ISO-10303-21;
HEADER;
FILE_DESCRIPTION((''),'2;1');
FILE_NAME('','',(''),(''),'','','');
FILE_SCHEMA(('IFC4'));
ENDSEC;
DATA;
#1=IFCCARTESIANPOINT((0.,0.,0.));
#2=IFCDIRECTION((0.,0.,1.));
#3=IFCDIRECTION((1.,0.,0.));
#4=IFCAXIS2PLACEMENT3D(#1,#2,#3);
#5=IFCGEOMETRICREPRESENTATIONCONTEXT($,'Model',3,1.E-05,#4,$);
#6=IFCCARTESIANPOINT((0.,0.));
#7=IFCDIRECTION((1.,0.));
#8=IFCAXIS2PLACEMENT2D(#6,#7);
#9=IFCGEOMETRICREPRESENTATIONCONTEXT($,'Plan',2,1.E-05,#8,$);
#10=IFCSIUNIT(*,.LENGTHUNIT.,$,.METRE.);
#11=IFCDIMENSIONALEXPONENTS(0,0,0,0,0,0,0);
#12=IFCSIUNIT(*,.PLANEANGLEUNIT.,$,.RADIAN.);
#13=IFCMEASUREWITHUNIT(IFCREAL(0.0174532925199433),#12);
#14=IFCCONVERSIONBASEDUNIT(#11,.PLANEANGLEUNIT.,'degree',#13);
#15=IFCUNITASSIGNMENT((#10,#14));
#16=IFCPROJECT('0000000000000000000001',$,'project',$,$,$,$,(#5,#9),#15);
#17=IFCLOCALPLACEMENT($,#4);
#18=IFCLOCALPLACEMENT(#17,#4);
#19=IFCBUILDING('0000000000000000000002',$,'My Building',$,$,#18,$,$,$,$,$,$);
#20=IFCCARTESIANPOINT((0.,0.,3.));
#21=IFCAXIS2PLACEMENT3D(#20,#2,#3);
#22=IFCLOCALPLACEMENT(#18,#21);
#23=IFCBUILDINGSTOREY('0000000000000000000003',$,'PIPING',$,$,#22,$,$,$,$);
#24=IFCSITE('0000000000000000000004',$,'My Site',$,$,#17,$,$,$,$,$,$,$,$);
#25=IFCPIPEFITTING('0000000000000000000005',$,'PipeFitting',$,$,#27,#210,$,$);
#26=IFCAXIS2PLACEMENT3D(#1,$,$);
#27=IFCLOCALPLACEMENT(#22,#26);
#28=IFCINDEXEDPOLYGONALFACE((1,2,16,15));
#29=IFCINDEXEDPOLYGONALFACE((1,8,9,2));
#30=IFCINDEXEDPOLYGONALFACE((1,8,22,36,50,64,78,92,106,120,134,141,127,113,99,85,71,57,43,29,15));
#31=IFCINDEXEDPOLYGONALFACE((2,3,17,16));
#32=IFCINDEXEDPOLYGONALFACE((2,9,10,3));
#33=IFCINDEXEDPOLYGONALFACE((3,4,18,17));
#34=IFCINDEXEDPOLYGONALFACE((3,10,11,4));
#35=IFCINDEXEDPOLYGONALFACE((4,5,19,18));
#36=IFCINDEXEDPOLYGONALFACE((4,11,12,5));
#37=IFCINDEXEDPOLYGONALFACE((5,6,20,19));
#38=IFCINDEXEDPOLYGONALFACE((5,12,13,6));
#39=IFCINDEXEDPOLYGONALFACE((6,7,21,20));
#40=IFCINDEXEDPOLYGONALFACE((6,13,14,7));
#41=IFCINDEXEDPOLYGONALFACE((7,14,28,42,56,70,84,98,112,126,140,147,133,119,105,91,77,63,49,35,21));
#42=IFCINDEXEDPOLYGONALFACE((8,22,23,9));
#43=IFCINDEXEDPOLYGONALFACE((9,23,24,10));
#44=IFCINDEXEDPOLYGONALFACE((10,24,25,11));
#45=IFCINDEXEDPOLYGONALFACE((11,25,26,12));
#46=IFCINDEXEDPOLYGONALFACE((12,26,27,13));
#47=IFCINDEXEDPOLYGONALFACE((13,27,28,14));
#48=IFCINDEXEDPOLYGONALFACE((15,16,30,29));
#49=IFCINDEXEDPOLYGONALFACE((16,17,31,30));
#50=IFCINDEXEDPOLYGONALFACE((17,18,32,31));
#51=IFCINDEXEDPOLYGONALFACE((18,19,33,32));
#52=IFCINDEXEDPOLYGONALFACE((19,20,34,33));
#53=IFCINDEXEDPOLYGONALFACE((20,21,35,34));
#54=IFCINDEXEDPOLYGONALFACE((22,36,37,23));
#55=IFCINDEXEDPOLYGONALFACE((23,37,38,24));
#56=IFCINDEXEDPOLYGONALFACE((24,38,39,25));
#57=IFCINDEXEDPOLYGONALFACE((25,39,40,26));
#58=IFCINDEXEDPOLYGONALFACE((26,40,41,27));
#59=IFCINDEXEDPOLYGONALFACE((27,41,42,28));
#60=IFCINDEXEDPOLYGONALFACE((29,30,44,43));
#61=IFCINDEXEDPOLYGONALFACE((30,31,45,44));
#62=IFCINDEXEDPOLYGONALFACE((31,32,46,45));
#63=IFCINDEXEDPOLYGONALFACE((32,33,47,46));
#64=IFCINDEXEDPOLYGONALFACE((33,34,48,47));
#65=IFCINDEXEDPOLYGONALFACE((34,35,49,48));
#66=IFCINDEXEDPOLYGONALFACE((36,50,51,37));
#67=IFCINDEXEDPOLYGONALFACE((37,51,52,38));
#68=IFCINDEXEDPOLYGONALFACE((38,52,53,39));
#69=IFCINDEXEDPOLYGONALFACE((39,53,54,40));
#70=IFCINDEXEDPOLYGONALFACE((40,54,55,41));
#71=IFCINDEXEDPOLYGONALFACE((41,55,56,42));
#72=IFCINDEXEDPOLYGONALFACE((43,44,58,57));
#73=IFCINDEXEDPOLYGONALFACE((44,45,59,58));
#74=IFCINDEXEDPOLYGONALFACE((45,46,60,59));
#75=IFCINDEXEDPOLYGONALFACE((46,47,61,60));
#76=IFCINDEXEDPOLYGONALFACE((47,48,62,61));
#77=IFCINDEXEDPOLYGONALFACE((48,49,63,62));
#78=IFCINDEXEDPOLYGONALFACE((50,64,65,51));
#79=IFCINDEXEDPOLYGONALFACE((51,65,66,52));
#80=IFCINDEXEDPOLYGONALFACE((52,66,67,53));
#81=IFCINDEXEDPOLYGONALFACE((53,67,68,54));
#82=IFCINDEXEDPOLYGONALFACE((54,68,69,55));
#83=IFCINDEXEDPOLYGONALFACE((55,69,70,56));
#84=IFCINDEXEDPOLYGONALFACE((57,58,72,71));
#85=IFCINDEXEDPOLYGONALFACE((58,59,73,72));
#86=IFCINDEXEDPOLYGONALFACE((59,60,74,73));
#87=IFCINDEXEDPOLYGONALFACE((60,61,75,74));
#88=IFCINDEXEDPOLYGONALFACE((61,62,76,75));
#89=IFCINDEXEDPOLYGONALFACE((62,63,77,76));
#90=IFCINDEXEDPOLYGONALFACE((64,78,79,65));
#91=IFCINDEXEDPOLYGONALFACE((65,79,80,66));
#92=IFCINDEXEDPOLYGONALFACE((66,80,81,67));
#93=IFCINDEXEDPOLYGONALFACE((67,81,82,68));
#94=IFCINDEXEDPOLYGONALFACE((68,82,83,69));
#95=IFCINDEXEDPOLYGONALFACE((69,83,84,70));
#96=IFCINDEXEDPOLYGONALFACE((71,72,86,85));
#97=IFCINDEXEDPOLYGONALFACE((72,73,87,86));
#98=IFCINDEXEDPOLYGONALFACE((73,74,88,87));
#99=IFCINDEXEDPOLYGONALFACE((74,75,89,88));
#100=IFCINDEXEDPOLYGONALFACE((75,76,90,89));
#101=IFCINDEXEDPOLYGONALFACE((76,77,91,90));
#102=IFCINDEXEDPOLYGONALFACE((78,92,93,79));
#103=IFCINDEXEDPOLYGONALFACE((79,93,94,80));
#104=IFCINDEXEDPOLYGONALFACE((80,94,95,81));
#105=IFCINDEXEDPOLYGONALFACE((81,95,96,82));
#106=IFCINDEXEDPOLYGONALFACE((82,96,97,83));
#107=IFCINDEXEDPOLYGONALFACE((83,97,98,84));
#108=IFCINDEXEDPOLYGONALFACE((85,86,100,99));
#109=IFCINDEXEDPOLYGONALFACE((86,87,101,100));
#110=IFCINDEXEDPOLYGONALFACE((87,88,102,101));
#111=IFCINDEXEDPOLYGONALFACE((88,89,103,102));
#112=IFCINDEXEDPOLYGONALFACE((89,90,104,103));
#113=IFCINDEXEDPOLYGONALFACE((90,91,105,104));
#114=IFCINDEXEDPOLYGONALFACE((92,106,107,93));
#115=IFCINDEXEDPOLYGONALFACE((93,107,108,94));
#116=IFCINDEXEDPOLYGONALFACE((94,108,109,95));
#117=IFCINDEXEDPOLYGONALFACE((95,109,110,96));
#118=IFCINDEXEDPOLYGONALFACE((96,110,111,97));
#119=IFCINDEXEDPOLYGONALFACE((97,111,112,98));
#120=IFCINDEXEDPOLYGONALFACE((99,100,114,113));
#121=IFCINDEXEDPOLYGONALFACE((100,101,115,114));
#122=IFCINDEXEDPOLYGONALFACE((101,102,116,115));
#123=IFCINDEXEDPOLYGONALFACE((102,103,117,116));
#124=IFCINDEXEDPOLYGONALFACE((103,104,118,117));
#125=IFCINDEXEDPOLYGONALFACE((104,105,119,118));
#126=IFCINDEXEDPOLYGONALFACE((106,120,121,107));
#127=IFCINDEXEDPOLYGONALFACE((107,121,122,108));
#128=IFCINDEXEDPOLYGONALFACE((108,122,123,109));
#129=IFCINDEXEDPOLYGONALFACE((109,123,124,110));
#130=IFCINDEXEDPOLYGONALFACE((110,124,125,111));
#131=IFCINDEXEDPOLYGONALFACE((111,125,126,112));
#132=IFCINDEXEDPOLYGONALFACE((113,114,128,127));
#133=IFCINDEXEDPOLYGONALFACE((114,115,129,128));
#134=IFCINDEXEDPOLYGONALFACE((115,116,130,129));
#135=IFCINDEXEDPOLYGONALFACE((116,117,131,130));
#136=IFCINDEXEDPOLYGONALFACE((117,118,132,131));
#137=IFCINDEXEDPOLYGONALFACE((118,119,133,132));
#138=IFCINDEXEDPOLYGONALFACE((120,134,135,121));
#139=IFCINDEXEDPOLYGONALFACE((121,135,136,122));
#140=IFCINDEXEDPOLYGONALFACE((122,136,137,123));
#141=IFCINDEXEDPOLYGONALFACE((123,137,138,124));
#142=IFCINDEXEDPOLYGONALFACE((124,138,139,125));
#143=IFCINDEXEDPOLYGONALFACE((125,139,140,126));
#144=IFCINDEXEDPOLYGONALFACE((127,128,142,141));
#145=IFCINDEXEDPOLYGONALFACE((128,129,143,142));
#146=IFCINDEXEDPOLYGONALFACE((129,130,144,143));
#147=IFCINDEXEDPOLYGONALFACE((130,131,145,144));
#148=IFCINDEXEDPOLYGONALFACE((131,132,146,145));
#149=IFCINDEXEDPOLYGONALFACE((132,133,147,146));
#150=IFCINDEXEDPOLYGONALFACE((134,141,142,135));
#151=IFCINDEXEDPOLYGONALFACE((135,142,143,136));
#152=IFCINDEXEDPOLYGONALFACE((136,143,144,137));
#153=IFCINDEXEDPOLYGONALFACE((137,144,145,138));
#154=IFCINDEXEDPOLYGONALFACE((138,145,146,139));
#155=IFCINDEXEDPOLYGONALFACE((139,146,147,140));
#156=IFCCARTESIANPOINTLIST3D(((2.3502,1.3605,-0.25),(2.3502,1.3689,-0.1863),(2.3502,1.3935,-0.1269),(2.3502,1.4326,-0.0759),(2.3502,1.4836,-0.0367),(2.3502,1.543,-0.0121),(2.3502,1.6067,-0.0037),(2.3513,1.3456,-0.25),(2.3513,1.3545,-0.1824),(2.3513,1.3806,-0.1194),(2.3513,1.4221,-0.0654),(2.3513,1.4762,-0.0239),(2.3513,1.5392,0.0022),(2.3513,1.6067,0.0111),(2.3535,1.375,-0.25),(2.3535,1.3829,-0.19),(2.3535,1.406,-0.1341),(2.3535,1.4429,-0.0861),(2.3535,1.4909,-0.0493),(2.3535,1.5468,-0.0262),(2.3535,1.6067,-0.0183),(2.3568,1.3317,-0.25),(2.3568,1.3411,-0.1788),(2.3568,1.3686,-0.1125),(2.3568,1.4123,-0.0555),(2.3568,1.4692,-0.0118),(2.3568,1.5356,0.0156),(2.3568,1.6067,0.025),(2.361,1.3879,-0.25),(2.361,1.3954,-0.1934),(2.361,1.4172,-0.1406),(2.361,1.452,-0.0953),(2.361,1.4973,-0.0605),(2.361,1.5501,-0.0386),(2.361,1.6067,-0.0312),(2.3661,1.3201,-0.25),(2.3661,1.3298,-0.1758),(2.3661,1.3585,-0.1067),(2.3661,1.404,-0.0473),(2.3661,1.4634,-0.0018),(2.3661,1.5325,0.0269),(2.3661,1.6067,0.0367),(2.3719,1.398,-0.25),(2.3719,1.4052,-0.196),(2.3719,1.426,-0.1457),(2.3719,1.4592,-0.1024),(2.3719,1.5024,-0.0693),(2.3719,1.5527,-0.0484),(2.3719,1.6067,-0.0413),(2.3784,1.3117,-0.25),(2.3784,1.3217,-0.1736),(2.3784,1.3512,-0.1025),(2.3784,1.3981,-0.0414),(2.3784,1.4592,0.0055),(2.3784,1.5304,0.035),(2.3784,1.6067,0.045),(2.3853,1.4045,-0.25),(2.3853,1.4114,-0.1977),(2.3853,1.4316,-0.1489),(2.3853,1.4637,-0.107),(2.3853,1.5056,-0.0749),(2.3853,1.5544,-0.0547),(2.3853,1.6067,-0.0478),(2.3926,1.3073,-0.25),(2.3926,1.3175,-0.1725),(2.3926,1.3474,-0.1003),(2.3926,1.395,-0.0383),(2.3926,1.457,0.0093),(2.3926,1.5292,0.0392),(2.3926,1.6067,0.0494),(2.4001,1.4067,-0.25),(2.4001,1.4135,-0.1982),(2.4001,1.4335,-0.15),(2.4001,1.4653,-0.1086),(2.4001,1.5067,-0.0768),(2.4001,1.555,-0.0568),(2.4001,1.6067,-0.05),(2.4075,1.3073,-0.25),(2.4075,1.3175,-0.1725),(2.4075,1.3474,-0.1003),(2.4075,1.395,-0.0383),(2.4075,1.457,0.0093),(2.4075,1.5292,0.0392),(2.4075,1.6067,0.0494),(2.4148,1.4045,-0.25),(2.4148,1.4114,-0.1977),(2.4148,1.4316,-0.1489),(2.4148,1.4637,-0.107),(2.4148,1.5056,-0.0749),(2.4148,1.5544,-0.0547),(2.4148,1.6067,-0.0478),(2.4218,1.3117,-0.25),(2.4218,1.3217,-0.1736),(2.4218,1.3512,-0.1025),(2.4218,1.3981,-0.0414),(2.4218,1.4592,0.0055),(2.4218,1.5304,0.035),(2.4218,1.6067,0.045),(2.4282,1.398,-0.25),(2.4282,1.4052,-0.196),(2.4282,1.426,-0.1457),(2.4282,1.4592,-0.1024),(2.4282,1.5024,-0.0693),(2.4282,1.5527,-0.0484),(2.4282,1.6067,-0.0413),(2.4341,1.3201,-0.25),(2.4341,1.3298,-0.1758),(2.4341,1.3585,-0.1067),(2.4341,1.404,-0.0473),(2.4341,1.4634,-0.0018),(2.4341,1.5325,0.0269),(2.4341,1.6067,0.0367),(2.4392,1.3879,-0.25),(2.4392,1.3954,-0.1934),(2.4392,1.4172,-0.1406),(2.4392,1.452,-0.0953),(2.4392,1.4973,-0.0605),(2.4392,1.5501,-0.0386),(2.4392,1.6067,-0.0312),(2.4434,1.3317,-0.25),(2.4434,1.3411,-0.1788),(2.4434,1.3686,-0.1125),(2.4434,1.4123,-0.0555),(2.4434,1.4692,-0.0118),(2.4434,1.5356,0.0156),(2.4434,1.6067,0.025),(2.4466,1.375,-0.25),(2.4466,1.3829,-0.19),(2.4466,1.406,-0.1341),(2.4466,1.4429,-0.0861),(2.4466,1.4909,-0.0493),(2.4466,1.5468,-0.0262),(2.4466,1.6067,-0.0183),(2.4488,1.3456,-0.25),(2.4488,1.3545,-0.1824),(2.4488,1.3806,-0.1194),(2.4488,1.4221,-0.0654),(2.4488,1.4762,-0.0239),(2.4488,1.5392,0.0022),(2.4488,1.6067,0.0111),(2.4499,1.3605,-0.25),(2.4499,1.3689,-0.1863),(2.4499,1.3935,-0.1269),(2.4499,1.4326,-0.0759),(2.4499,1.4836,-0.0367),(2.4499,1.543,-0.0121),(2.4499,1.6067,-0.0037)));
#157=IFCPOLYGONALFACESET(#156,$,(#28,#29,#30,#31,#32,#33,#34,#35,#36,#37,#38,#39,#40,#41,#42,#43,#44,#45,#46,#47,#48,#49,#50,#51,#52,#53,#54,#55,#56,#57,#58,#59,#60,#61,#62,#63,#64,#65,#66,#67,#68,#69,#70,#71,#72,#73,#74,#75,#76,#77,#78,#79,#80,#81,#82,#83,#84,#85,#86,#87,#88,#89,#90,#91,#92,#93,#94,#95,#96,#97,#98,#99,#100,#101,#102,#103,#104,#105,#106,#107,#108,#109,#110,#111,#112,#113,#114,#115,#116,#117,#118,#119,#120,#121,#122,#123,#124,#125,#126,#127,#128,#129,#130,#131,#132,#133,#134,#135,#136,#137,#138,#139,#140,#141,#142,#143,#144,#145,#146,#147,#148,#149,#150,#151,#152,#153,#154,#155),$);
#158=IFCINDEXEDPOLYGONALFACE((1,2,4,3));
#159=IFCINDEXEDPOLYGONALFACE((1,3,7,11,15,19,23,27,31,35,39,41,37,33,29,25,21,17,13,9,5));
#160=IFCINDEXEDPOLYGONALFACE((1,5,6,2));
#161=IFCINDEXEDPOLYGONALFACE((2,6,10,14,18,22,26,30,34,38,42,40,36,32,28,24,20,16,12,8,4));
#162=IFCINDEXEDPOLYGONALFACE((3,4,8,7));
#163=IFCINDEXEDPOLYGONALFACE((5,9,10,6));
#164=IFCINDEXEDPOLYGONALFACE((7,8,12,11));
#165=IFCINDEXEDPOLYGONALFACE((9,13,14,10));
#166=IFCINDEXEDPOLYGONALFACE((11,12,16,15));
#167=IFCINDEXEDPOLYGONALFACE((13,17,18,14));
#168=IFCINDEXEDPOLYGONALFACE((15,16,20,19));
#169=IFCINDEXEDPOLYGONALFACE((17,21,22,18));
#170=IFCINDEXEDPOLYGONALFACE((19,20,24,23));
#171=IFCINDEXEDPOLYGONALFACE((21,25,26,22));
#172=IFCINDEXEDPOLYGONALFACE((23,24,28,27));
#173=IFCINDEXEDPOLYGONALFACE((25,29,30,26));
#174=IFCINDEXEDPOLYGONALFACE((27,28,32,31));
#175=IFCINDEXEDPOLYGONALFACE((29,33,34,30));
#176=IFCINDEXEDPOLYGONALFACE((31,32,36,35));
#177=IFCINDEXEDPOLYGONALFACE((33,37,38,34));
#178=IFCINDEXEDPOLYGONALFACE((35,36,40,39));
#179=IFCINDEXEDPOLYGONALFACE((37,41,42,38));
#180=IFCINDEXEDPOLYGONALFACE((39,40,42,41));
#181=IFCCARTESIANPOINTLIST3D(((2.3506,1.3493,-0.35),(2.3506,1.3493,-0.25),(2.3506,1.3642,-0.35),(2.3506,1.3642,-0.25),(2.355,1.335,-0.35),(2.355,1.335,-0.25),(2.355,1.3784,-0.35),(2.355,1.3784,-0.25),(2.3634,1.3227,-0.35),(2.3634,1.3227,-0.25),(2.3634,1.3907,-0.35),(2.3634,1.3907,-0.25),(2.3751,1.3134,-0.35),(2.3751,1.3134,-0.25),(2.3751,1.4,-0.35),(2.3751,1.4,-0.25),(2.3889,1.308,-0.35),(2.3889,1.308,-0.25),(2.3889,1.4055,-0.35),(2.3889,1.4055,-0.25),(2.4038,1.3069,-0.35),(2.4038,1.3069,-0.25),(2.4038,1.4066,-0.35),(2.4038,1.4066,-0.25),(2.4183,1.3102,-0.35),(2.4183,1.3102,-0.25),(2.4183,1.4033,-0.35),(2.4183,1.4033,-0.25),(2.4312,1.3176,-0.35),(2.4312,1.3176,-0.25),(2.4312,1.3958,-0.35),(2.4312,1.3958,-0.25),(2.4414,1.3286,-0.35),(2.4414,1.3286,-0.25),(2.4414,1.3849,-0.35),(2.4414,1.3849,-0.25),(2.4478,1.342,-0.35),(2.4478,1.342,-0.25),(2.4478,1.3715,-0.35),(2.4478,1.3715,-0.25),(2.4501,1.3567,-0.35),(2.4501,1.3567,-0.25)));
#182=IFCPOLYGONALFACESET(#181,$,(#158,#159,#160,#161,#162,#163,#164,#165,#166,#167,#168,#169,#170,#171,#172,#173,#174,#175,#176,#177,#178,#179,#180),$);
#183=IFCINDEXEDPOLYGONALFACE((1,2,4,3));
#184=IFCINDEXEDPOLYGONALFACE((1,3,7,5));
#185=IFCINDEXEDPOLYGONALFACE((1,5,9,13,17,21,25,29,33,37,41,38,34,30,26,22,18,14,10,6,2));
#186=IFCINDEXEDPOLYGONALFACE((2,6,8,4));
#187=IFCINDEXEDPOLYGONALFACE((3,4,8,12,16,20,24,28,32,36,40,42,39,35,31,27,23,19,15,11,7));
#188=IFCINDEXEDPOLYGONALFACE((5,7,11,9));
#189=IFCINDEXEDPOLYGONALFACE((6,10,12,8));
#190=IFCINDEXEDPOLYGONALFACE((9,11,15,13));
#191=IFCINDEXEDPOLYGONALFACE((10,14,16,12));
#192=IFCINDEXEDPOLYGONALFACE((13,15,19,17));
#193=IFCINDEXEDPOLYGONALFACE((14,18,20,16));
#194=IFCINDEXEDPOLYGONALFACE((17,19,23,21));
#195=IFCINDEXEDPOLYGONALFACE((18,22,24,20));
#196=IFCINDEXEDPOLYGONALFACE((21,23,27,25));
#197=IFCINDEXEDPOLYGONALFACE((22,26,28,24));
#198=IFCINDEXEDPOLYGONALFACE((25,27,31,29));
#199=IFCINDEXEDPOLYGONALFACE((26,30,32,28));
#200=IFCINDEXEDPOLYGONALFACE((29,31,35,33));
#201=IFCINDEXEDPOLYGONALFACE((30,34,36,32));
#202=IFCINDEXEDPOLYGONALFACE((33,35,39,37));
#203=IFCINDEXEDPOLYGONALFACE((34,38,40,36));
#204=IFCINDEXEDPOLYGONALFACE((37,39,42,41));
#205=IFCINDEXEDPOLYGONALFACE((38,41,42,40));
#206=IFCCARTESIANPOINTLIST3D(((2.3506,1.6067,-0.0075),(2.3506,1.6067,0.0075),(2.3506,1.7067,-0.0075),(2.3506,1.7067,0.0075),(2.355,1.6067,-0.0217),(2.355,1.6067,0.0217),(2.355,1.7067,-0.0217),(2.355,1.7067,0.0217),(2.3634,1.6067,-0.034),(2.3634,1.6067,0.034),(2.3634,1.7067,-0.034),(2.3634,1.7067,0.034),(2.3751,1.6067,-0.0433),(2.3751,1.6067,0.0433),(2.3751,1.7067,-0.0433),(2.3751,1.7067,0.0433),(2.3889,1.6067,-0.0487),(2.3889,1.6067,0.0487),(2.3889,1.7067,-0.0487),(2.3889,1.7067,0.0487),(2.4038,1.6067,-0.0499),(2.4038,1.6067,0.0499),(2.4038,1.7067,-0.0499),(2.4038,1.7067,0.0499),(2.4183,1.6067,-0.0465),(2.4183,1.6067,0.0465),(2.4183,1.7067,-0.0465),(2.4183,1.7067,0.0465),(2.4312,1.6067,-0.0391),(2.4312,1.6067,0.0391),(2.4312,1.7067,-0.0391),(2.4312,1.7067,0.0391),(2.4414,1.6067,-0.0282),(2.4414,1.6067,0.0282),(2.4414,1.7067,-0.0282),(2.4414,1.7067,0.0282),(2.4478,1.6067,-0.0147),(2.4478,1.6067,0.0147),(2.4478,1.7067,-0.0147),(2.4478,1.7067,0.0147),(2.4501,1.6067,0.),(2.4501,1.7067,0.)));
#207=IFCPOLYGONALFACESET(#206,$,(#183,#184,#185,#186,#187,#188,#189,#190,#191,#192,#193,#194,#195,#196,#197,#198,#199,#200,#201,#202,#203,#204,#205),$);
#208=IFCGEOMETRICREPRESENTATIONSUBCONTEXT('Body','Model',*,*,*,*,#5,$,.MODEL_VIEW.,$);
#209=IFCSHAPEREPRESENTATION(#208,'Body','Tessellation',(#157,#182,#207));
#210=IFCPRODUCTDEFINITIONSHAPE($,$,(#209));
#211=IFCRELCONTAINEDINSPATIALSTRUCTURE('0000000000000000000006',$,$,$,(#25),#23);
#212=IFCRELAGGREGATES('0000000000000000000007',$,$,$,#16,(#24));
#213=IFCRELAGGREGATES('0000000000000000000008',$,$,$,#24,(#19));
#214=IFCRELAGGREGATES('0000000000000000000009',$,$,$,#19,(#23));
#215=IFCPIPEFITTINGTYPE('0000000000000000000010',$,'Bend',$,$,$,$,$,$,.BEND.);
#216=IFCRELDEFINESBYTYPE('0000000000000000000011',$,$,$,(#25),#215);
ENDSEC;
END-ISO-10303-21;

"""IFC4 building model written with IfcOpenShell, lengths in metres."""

from ifc_helpers import new_model, entity, si_unit, converted_unit, frame, origin_with_axes, origin_2d_with_axis, place, context, subcontext, project, spatial, circle, extrude, source, transform, mapped, type_object, type_shapes, element, save


model = new_model("IFC4")

# Units and contexts
model_context = context("Model", 3, precision=1e-05, world=origin_with_axes())
plan_context = context("Plan", 2, precision=1e-05, world=origin_2d_with_axis())
body_context = subcontext(model_context, "Body", "Model", "MODEL_VIEW")
ifc_project = project(units=[si_unit("LENGTHUNIT", "METRE"), converted_unit("PLANEANGLEUNIT", "degree", entity("IfcReal", 0.0174532925199433), si_unit("PLANEANGLEUNIT", "RADIAN"), dimensions=[0, 0, 0, 0, 0, 0, 0])], contexts=[model_context, plan_context])

# Site, building, storey
site_placement = place(None, origin_with_axes())
site = spatial("IfcSite", under=ifc_project, at=site_placement, Name="My Site")
building_placement = place(site_placement, origin_with_axes())
building = spatial("IfcBuilding", under=site, at=building_placement, Name="My Building")
storey_placement = place(building_placement, frame((0.0, 0.0, 3.0), z_axis=(0.0, 0.0, 1.0), x_axis=(1.0, 0.0, 0.0)))
storey = spatial("IfcBuildingStorey", under=building, at=storey_placement, Name="PIPING")

# Pipe fitting
pipe_fitting_type_1 = type_object("IfcPipeFittingType", Name="Bend", PredefinedType="BEND")
shared_shape = source(origin_with_axes(), body_context, "Body", "SolidModel", [
    entity("IfcSweptDiskSolid", entity("IfcIndexedPolyCurve", entity("IfcCartesianPointList3D", [[0.0, 0.0, -0.1], [0.0, -0.0732, -0.2768], [0.0, -0.25, -0.35]]), [entity("IfcArcIndex", [1, 2, 3])]), 0.05),
    extrude(circle(Radius=0.05), origin_with_axes(), (0.0, 0.0, -1.0), 0.1),
    extrude(circle(Radius=0.05), frame((0.0, -0.25, -0.35), z_axis=(0.0, -1.0, 0.0), x_axis=(1.0, 0.0, 0.0)), (0.0, 0.0, 1.0), 0.1),
])
type_shapes(pipe_fitting_type_1, [shared_shape])
for number, where, z_axis, x_axis, name in (
    (1, (2.4001, 1.3567, -0.35), (0.0, 0.0, -1.0), (1.0, 0.0, 0.0), "PipeFitting"),
):
    element("IfcPipeFitting", number, at=place(storey_placement, frame(where, z_axis=z_axis, x_axis=x_axis)), inside=storey, type_object=pipe_fitting_type_1, Name=name, context=body_context, shape_type="MappedRepresentation", body=[
        mapped(shared_shape, transform((0.0, 0.0, 0.0), x_axis=(1.0, 0.0, 0.0), y_axis=(0.0, 1.0, 0.0), z_axis=(0.0, 0.0, 1.0), scale=1.0)),
    ])

save(model, "model.ifc")
